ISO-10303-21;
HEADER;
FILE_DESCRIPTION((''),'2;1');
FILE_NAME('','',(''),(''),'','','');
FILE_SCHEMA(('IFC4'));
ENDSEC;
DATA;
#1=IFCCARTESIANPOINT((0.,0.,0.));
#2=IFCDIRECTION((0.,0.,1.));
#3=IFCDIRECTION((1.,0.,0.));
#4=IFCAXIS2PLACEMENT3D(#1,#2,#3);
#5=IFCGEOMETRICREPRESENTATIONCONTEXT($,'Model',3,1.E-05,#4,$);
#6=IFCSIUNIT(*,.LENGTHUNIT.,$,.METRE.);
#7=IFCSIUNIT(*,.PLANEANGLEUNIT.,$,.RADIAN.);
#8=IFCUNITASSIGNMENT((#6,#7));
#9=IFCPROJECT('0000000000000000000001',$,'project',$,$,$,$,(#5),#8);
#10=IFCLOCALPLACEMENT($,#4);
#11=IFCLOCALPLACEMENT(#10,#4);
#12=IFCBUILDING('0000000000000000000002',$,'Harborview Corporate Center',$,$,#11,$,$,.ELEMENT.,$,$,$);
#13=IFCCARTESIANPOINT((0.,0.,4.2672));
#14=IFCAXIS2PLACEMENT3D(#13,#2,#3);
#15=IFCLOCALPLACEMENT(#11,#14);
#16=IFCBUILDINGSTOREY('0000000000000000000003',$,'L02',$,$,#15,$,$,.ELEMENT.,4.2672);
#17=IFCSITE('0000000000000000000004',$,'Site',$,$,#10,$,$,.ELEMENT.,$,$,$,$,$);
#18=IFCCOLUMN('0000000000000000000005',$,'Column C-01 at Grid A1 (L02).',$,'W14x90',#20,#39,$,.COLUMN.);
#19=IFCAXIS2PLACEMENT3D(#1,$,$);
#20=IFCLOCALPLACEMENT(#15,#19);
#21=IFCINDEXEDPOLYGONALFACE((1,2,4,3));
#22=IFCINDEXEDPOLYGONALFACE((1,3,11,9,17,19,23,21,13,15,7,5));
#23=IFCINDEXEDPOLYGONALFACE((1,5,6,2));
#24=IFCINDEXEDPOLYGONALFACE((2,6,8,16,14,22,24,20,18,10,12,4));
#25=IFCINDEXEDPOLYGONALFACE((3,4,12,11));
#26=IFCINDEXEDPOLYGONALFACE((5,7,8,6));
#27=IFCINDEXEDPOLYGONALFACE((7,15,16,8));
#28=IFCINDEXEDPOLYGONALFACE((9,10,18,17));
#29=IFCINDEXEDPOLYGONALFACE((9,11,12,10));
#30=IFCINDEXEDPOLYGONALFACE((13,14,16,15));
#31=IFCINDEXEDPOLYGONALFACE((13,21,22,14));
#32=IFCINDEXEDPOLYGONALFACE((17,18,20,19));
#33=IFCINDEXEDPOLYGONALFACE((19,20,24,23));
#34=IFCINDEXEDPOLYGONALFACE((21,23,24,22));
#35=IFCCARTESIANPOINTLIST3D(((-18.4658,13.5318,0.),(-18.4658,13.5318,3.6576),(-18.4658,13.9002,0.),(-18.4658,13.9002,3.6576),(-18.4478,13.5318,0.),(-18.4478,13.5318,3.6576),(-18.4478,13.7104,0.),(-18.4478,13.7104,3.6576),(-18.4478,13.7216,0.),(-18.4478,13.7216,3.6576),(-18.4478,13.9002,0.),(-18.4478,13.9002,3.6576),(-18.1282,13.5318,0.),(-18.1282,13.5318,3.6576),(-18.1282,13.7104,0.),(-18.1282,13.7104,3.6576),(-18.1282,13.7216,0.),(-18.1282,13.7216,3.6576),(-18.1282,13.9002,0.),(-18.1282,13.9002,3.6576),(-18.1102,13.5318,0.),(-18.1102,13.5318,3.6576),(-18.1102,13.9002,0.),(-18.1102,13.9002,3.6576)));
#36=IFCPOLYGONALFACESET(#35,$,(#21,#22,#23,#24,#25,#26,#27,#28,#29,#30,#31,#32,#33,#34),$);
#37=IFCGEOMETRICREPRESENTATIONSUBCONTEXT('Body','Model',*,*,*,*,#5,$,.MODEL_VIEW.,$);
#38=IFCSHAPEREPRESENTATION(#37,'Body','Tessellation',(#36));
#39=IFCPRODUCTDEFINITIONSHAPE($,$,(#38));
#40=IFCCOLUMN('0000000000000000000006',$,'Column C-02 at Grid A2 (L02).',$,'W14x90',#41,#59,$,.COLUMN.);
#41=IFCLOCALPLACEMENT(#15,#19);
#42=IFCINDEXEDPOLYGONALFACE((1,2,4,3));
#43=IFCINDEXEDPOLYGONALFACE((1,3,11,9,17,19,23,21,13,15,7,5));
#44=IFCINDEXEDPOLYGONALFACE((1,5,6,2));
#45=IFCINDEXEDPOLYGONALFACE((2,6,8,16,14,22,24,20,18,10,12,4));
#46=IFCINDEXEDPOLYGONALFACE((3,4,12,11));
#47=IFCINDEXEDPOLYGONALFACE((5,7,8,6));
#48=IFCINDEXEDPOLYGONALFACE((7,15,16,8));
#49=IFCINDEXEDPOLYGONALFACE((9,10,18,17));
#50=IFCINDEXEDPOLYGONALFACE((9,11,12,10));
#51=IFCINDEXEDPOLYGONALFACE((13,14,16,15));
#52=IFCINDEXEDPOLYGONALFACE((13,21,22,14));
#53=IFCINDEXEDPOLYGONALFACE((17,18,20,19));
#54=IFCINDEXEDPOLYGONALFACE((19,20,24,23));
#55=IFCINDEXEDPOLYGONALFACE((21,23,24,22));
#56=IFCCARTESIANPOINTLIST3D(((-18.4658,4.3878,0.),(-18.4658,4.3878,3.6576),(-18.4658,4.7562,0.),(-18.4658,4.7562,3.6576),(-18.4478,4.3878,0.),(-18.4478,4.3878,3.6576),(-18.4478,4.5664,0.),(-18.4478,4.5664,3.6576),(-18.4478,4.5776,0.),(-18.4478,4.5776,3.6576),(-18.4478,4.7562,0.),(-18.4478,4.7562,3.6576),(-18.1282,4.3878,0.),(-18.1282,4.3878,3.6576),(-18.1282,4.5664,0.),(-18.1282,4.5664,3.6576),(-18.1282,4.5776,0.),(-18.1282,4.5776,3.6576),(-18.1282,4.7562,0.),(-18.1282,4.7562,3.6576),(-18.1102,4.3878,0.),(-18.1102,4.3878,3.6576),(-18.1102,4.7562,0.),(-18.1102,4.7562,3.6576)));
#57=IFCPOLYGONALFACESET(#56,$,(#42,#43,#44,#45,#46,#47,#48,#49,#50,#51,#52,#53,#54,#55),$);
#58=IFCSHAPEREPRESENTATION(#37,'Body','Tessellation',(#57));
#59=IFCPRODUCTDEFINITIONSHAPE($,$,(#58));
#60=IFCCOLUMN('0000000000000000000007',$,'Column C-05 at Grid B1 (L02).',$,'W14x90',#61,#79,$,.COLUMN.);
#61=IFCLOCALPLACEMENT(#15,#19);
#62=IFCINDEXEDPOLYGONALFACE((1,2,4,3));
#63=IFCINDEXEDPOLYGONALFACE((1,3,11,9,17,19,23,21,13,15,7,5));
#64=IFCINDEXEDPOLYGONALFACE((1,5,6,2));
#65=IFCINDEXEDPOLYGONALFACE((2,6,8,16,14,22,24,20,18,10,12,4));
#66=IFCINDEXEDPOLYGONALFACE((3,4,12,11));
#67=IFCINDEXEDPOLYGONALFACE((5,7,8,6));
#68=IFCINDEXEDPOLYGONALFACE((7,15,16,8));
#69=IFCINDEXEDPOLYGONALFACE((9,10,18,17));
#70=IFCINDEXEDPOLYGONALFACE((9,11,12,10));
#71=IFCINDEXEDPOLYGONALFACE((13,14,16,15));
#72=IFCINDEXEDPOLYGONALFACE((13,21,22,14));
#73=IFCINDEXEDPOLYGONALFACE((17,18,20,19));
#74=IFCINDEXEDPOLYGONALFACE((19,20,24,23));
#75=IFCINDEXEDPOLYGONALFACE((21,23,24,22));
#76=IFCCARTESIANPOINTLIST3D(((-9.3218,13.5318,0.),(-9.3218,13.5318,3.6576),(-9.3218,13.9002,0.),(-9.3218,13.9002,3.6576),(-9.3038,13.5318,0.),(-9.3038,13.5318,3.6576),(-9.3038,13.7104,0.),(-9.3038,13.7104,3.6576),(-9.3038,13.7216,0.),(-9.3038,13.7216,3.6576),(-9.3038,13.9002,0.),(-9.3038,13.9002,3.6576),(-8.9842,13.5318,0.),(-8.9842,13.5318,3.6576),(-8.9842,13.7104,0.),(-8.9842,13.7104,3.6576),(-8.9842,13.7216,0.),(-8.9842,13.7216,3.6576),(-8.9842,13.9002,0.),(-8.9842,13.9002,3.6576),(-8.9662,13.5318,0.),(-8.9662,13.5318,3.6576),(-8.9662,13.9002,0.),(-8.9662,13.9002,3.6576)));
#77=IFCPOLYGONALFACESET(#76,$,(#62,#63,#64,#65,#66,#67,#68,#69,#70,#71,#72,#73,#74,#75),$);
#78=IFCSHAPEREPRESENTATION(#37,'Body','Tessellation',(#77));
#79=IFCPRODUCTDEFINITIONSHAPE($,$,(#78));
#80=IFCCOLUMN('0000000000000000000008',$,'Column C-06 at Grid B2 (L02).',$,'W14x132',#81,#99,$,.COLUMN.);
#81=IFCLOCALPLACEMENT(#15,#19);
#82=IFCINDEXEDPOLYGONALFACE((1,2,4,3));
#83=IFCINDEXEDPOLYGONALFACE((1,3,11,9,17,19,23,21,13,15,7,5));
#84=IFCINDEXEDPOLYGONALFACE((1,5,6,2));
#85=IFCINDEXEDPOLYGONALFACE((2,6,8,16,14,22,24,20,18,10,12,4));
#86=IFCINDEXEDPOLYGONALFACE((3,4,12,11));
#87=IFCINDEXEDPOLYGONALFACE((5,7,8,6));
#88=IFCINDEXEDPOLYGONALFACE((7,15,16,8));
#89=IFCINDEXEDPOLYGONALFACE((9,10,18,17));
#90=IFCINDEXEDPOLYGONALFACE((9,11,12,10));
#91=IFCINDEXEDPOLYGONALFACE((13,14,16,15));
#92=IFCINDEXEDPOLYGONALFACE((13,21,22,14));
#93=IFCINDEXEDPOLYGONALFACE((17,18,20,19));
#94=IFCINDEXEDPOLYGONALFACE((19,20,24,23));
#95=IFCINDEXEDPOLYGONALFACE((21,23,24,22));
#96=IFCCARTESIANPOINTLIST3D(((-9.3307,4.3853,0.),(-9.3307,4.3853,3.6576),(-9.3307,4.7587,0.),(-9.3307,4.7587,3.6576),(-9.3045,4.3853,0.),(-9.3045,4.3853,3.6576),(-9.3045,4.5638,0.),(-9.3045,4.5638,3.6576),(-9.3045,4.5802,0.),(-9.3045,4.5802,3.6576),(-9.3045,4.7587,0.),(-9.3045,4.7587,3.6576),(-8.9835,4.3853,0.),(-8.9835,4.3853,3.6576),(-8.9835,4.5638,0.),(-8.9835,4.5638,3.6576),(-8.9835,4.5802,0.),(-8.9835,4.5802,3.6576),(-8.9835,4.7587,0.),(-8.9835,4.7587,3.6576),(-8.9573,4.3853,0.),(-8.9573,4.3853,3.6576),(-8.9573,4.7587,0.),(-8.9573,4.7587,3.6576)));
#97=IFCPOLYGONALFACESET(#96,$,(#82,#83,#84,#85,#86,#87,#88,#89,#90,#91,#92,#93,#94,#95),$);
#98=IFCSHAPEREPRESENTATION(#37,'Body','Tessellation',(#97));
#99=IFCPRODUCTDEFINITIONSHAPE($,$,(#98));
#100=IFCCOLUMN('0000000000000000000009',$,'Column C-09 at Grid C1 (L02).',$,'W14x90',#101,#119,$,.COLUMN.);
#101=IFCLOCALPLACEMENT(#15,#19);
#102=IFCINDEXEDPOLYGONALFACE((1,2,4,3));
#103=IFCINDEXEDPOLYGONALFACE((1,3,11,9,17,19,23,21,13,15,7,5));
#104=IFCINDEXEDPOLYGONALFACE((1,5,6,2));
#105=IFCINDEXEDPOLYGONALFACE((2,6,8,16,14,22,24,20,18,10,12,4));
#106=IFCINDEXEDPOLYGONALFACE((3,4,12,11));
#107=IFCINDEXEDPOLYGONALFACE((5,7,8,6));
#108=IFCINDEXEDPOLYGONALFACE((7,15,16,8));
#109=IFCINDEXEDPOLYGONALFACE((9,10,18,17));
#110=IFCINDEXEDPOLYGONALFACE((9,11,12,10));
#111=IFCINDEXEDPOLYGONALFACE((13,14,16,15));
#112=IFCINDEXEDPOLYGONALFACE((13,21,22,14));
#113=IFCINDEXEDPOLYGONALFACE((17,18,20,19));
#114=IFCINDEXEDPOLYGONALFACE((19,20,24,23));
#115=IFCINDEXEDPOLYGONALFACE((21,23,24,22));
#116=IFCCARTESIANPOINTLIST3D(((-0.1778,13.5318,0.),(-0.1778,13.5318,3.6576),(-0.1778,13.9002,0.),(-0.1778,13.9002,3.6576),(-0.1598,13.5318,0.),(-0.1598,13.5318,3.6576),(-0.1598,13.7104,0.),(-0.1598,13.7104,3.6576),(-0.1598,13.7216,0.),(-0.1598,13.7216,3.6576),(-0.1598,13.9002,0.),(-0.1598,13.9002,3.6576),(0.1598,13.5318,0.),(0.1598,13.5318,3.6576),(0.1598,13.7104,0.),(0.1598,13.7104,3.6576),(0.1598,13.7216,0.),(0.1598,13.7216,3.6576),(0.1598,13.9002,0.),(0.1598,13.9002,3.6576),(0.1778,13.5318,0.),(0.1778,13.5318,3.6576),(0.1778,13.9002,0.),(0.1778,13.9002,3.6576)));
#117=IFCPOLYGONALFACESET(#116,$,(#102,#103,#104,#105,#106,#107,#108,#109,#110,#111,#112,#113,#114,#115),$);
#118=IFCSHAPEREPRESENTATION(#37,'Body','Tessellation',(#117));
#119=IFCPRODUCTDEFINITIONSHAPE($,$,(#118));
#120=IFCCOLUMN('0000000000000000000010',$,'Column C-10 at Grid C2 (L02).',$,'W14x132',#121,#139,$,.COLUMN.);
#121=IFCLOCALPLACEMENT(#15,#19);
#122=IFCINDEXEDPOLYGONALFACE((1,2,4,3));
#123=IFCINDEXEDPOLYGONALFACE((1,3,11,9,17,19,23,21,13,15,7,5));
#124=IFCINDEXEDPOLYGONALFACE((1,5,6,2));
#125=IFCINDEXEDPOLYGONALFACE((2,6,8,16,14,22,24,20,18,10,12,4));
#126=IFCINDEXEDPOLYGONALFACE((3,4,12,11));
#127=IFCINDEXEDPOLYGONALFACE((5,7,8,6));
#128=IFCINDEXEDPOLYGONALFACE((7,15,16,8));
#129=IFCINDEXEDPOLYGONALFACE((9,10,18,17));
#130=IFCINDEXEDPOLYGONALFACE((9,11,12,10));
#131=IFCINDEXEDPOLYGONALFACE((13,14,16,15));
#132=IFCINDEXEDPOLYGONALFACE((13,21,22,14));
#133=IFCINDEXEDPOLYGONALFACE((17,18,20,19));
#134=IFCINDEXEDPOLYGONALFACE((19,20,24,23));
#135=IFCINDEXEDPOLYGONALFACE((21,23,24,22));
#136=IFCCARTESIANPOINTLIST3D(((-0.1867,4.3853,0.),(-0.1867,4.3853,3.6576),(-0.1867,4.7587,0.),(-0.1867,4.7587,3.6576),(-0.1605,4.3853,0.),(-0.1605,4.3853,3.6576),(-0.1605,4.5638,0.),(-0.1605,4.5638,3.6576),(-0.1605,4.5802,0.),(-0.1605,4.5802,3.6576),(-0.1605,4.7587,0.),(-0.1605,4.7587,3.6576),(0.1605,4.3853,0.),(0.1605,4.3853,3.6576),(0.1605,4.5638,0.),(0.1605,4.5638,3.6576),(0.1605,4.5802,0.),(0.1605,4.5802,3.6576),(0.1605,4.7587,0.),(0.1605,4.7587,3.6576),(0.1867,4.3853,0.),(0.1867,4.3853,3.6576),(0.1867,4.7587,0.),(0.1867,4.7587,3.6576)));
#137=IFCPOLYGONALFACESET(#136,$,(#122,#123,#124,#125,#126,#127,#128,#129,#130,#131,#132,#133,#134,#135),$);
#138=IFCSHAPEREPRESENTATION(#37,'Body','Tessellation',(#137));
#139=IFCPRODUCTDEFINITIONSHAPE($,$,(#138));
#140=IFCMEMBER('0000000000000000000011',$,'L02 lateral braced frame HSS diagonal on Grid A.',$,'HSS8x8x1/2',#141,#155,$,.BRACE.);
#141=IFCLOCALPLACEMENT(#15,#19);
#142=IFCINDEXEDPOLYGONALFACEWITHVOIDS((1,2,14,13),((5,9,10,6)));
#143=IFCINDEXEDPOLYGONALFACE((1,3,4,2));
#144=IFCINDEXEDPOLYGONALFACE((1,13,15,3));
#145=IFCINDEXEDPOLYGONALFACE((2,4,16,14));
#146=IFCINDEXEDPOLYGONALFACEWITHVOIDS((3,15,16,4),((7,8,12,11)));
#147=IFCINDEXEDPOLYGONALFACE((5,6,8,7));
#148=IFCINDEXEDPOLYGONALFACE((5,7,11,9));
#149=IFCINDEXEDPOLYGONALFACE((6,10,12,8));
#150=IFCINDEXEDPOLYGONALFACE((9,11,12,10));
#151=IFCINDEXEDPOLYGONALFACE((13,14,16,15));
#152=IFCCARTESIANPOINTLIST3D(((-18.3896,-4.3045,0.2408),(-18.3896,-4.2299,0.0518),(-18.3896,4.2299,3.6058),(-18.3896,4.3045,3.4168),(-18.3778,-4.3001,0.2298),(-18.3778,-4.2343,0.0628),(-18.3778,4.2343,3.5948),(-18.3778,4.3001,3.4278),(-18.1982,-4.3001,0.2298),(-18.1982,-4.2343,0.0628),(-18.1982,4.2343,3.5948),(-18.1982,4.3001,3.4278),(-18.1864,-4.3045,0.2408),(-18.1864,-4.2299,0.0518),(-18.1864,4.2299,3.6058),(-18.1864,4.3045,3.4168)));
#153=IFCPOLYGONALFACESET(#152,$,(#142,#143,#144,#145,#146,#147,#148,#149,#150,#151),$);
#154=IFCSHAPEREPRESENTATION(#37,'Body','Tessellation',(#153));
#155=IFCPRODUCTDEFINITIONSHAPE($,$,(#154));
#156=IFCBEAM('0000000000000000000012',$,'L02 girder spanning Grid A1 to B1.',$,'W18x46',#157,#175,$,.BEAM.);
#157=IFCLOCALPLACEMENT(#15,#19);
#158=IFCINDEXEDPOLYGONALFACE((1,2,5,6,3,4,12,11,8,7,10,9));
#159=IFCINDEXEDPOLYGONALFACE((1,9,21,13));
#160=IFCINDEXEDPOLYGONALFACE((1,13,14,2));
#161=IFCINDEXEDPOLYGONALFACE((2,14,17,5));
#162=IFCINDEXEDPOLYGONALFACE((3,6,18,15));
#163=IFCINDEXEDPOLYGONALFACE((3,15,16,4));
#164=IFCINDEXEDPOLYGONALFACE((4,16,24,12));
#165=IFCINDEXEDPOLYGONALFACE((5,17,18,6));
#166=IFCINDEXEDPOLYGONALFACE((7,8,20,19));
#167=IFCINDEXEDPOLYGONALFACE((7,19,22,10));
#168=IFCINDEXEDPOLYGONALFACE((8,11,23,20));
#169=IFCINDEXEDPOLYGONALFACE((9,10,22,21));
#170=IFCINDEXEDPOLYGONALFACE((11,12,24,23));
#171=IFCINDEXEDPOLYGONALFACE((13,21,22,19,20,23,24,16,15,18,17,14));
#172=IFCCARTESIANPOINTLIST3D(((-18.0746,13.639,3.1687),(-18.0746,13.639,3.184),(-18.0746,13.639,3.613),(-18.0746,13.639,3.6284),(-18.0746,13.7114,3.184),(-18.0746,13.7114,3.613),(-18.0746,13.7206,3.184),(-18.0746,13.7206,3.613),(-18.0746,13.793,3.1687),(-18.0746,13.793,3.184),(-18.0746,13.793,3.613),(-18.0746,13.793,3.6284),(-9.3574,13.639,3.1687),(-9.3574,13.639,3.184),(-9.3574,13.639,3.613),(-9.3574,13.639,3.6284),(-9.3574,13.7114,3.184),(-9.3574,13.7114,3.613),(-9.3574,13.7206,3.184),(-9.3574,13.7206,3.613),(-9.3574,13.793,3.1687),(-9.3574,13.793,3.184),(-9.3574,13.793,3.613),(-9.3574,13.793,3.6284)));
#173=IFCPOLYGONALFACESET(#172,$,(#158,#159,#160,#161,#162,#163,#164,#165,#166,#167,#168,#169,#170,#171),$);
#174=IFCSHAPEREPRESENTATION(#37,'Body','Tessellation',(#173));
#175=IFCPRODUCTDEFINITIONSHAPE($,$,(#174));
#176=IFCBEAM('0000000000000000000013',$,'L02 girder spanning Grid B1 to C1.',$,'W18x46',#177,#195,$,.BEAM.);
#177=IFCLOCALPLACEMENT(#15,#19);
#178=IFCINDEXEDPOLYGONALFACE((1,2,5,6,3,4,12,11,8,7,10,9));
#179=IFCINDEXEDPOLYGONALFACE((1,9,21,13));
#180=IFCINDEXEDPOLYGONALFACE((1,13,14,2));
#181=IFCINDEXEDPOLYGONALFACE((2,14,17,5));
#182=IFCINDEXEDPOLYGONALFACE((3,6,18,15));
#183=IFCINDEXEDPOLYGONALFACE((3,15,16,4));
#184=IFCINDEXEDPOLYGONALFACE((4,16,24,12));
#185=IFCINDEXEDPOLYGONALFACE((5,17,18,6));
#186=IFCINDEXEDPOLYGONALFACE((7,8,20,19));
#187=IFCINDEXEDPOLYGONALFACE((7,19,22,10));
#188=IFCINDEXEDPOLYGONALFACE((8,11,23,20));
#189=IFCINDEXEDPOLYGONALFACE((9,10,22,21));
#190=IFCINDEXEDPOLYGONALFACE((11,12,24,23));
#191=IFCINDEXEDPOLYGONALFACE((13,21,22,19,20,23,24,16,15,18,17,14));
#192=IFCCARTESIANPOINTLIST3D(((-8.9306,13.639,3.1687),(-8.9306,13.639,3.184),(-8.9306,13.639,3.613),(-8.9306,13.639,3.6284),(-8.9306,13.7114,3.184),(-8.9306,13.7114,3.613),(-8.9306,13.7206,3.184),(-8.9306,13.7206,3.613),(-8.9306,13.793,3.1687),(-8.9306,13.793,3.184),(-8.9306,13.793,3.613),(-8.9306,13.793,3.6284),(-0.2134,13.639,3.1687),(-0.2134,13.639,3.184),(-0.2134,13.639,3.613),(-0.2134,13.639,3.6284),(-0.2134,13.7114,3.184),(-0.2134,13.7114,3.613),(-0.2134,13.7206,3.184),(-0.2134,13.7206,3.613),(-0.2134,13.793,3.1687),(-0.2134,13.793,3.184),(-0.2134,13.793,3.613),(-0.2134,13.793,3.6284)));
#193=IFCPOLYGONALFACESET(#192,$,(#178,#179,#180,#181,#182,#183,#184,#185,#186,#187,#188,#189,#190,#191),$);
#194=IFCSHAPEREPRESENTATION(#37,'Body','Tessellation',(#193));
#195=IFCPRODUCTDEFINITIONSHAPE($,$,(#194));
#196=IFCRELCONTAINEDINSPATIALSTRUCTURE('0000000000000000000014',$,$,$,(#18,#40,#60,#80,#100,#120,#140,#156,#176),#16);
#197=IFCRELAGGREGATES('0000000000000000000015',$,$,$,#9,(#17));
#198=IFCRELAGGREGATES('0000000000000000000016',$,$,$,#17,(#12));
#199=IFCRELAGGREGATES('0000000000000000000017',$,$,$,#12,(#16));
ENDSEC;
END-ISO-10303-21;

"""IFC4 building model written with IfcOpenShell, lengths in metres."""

from ifc_helpers import new_model, si_unit, frame, origin_with_axes, place, context, subcontext, project, spatial, hollow_rectangle, i_section, extrude, element, save


model = new_model("IFC4")

# Units and contexts
model_context = context("Model", 3, precision=1e-05, world=origin_with_axes())
body_context = subcontext(model_context, "Body", "Model", "MODEL_VIEW")
ifc_project = project(units=[si_unit("LENGTHUNIT", "METRE"), si_unit("PLANEANGLEUNIT", "RADIAN")], contexts=[model_context])

# Site, building, storey
site_placement = place(None, origin_with_axes())
site = spatial("IfcSite", under=ifc_project, at=site_placement, Name="Site", CompositionType="ELEMENT")
building_placement = place(site_placement, origin_with_axes())
building = spatial("IfcBuilding", under=site, at=building_placement, Name="Harborview Corporate Center", CompositionType="ELEMENT")
storey_placement = place(building_placement, frame((0.0, 0.0, 4.2672), z_axis=(0.0, 0.0, 1.0), x_axis=(1.0, 0.0, 0.0)))
storey = spatial("IfcBuildingStorey", under=building, at=storey_placement, Name="L02", CompositionType="ELEMENT", Elevation=4.2672)

# Columns
for number, where, z_axis, x_axis, name in (
    (1, (-18.288, 13.716, 0.0), (0.0, 0.0, 1.0), (0.0, 1.0, 0.0), "Column C-01 at Grid A1 (L02)."),
    (2, (-18.288, 4.572, 0.0), (0.0, 0.0, 1.0), (0.0, 1.0, 0.0), "Column C-02 at Grid A2 (L02)."),
    (3, (-9.144, 13.716, 0.0), (0.0, 0.0, 1.0), (0.0, 1.0, 0.0), "Column C-05 at Grid B1 (L02)."),
):
    element("IfcColumn", number, at=place(storey_placement, frame(where, z_axis=z_axis, x_axis=x_axis)), inside=storey, Name=name, ObjectType="W14x90", PredefinedType="COLUMN", context=body_context, shape_type="SweptSolid", body=[
        extrude(i_section(OverallWidth=0.3683, OverallDepth=0.3556, WebThickness=0.0112, FlangeThickness=0.018), origin_with_axes(), (0.0, 0.0, 1.0), 3.6576),
    ])
column_1_placement = place(storey_placement, frame((-9.144, 4.572, 0.0), z_axis=(0.0, 0.0, 1.0), x_axis=(0.0, 1.0, 0.0)))
element("IfcColumn", 4, at=column_1_placement, inside=storey, Name="Column C-06 at Grid B2 (L02).", ObjectType="W14x132", PredefinedType="COLUMN", context=body_context, shape_type="SweptSolid", body=[
    extrude(i_section(OverallWidth=0.3734, OverallDepth=0.3734, WebThickness=0.0164, FlangeThickness=0.0262), origin_with_axes(), (0.0, 0.0, 1.0), 3.6576),
])
column_2_placement = place(storey_placement, frame((0.0, 13.716, 0.0), z_axis=(0.0, 0.0, 1.0), x_axis=(0.0, 1.0, 0.0)))
element("IfcColumn", 5, at=column_2_placement, inside=storey, Name="Column C-09 at Grid C1 (L02).", ObjectType="W14x90", PredefinedType="COLUMN", context=body_context, shape_type="SweptSolid", body=[
    extrude(i_section(OverallWidth=0.3683, OverallDepth=0.3556, WebThickness=0.0112, FlangeThickness=0.018), origin_with_axes(), (0.0, 0.0, 1.0), 3.6576),
])
column_3_placement = place(storey_placement, frame((0.0, 4.572, 0.0), z_axis=(0.0, 0.0, 1.0), x_axis=(0.0, 1.0, 0.0)))
element("IfcColumn", 6, at=column_3_placement, inside=storey, Name="Column C-10 at Grid C2 (L02).", ObjectType="W14x132", PredefinedType="COLUMN", context=body_context, shape_type="SweptSolid", body=[
    extrude(i_section(OverallWidth=0.3734, OverallDepth=0.3734, WebThickness=0.0164, FlangeThickness=0.0262), origin_with_axes(), (0.0, 0.0, 1.0), 3.6576),
])

# Member
member_placement = place(storey_placement, frame((-18.288, -4.2672, 0.1463), z_axis=(0.0, 0.930298, 0.366803), x_axis=(-1.0, 0.0, 0.0)))
element("IfcMember", 7, at=member_placement, inside=storey, Name="L02 lateral braced frame HSS diagonal on Grid A.", ObjectType="HSS8x8x1/2", PredefinedType="BRACE", context=body_context, shape_type="SweptSolid", body=[
    extrude(hollow_rectangle(XDim=0.2032, YDim=0.2032, WallThickness=0.0118), origin_with_axes(), (0.0, 0.0, 1.0), 9.1738),
])

# Beams
beam_1_placement = place(storey_placement, frame((-18.0746, 13.716, 3.3985), z_axis=(1.0, 0.0, 0.0), x_axis=(0.0, 1.0, 0.0)))
element("IfcBeam", 8, at=beam_1_placement, inside=storey, Name="L02 girder spanning Grid A1 to B1.", ObjectType="W18x46", PredefinedType="BEAM", context=body_context, shape_type="SweptSolid", body=[
    extrude(i_section(OverallWidth=0.1539, OverallDepth=0.4597, WebThickness=0.0091, FlangeThickness=0.0154), origin_with_axes(), (0.0, 0.0, 1.0), 8.7173),
])
beam_2_placement = place(storey_placement, frame((-8.9306, 13.716, 3.3985), z_axis=(1.0, 0.0, 0.0), x_axis=(0.0, 1.0, 0.0)))
element("IfcBeam", 9, at=beam_2_placement, inside=storey, Name="L02 girder spanning Grid B1 to C1.", ObjectType="W18x46", PredefinedType="BEAM", context=body_context, shape_type="SweptSolid", body=[
    extrude(i_section(OverallWidth=0.1539, OverallDepth=0.4597, WebThickness=0.0091, FlangeThickness=0.0154), origin_with_axes(), (0.0, 0.0, 1.0), 8.7173),
])

save(model, "model.ifc")
